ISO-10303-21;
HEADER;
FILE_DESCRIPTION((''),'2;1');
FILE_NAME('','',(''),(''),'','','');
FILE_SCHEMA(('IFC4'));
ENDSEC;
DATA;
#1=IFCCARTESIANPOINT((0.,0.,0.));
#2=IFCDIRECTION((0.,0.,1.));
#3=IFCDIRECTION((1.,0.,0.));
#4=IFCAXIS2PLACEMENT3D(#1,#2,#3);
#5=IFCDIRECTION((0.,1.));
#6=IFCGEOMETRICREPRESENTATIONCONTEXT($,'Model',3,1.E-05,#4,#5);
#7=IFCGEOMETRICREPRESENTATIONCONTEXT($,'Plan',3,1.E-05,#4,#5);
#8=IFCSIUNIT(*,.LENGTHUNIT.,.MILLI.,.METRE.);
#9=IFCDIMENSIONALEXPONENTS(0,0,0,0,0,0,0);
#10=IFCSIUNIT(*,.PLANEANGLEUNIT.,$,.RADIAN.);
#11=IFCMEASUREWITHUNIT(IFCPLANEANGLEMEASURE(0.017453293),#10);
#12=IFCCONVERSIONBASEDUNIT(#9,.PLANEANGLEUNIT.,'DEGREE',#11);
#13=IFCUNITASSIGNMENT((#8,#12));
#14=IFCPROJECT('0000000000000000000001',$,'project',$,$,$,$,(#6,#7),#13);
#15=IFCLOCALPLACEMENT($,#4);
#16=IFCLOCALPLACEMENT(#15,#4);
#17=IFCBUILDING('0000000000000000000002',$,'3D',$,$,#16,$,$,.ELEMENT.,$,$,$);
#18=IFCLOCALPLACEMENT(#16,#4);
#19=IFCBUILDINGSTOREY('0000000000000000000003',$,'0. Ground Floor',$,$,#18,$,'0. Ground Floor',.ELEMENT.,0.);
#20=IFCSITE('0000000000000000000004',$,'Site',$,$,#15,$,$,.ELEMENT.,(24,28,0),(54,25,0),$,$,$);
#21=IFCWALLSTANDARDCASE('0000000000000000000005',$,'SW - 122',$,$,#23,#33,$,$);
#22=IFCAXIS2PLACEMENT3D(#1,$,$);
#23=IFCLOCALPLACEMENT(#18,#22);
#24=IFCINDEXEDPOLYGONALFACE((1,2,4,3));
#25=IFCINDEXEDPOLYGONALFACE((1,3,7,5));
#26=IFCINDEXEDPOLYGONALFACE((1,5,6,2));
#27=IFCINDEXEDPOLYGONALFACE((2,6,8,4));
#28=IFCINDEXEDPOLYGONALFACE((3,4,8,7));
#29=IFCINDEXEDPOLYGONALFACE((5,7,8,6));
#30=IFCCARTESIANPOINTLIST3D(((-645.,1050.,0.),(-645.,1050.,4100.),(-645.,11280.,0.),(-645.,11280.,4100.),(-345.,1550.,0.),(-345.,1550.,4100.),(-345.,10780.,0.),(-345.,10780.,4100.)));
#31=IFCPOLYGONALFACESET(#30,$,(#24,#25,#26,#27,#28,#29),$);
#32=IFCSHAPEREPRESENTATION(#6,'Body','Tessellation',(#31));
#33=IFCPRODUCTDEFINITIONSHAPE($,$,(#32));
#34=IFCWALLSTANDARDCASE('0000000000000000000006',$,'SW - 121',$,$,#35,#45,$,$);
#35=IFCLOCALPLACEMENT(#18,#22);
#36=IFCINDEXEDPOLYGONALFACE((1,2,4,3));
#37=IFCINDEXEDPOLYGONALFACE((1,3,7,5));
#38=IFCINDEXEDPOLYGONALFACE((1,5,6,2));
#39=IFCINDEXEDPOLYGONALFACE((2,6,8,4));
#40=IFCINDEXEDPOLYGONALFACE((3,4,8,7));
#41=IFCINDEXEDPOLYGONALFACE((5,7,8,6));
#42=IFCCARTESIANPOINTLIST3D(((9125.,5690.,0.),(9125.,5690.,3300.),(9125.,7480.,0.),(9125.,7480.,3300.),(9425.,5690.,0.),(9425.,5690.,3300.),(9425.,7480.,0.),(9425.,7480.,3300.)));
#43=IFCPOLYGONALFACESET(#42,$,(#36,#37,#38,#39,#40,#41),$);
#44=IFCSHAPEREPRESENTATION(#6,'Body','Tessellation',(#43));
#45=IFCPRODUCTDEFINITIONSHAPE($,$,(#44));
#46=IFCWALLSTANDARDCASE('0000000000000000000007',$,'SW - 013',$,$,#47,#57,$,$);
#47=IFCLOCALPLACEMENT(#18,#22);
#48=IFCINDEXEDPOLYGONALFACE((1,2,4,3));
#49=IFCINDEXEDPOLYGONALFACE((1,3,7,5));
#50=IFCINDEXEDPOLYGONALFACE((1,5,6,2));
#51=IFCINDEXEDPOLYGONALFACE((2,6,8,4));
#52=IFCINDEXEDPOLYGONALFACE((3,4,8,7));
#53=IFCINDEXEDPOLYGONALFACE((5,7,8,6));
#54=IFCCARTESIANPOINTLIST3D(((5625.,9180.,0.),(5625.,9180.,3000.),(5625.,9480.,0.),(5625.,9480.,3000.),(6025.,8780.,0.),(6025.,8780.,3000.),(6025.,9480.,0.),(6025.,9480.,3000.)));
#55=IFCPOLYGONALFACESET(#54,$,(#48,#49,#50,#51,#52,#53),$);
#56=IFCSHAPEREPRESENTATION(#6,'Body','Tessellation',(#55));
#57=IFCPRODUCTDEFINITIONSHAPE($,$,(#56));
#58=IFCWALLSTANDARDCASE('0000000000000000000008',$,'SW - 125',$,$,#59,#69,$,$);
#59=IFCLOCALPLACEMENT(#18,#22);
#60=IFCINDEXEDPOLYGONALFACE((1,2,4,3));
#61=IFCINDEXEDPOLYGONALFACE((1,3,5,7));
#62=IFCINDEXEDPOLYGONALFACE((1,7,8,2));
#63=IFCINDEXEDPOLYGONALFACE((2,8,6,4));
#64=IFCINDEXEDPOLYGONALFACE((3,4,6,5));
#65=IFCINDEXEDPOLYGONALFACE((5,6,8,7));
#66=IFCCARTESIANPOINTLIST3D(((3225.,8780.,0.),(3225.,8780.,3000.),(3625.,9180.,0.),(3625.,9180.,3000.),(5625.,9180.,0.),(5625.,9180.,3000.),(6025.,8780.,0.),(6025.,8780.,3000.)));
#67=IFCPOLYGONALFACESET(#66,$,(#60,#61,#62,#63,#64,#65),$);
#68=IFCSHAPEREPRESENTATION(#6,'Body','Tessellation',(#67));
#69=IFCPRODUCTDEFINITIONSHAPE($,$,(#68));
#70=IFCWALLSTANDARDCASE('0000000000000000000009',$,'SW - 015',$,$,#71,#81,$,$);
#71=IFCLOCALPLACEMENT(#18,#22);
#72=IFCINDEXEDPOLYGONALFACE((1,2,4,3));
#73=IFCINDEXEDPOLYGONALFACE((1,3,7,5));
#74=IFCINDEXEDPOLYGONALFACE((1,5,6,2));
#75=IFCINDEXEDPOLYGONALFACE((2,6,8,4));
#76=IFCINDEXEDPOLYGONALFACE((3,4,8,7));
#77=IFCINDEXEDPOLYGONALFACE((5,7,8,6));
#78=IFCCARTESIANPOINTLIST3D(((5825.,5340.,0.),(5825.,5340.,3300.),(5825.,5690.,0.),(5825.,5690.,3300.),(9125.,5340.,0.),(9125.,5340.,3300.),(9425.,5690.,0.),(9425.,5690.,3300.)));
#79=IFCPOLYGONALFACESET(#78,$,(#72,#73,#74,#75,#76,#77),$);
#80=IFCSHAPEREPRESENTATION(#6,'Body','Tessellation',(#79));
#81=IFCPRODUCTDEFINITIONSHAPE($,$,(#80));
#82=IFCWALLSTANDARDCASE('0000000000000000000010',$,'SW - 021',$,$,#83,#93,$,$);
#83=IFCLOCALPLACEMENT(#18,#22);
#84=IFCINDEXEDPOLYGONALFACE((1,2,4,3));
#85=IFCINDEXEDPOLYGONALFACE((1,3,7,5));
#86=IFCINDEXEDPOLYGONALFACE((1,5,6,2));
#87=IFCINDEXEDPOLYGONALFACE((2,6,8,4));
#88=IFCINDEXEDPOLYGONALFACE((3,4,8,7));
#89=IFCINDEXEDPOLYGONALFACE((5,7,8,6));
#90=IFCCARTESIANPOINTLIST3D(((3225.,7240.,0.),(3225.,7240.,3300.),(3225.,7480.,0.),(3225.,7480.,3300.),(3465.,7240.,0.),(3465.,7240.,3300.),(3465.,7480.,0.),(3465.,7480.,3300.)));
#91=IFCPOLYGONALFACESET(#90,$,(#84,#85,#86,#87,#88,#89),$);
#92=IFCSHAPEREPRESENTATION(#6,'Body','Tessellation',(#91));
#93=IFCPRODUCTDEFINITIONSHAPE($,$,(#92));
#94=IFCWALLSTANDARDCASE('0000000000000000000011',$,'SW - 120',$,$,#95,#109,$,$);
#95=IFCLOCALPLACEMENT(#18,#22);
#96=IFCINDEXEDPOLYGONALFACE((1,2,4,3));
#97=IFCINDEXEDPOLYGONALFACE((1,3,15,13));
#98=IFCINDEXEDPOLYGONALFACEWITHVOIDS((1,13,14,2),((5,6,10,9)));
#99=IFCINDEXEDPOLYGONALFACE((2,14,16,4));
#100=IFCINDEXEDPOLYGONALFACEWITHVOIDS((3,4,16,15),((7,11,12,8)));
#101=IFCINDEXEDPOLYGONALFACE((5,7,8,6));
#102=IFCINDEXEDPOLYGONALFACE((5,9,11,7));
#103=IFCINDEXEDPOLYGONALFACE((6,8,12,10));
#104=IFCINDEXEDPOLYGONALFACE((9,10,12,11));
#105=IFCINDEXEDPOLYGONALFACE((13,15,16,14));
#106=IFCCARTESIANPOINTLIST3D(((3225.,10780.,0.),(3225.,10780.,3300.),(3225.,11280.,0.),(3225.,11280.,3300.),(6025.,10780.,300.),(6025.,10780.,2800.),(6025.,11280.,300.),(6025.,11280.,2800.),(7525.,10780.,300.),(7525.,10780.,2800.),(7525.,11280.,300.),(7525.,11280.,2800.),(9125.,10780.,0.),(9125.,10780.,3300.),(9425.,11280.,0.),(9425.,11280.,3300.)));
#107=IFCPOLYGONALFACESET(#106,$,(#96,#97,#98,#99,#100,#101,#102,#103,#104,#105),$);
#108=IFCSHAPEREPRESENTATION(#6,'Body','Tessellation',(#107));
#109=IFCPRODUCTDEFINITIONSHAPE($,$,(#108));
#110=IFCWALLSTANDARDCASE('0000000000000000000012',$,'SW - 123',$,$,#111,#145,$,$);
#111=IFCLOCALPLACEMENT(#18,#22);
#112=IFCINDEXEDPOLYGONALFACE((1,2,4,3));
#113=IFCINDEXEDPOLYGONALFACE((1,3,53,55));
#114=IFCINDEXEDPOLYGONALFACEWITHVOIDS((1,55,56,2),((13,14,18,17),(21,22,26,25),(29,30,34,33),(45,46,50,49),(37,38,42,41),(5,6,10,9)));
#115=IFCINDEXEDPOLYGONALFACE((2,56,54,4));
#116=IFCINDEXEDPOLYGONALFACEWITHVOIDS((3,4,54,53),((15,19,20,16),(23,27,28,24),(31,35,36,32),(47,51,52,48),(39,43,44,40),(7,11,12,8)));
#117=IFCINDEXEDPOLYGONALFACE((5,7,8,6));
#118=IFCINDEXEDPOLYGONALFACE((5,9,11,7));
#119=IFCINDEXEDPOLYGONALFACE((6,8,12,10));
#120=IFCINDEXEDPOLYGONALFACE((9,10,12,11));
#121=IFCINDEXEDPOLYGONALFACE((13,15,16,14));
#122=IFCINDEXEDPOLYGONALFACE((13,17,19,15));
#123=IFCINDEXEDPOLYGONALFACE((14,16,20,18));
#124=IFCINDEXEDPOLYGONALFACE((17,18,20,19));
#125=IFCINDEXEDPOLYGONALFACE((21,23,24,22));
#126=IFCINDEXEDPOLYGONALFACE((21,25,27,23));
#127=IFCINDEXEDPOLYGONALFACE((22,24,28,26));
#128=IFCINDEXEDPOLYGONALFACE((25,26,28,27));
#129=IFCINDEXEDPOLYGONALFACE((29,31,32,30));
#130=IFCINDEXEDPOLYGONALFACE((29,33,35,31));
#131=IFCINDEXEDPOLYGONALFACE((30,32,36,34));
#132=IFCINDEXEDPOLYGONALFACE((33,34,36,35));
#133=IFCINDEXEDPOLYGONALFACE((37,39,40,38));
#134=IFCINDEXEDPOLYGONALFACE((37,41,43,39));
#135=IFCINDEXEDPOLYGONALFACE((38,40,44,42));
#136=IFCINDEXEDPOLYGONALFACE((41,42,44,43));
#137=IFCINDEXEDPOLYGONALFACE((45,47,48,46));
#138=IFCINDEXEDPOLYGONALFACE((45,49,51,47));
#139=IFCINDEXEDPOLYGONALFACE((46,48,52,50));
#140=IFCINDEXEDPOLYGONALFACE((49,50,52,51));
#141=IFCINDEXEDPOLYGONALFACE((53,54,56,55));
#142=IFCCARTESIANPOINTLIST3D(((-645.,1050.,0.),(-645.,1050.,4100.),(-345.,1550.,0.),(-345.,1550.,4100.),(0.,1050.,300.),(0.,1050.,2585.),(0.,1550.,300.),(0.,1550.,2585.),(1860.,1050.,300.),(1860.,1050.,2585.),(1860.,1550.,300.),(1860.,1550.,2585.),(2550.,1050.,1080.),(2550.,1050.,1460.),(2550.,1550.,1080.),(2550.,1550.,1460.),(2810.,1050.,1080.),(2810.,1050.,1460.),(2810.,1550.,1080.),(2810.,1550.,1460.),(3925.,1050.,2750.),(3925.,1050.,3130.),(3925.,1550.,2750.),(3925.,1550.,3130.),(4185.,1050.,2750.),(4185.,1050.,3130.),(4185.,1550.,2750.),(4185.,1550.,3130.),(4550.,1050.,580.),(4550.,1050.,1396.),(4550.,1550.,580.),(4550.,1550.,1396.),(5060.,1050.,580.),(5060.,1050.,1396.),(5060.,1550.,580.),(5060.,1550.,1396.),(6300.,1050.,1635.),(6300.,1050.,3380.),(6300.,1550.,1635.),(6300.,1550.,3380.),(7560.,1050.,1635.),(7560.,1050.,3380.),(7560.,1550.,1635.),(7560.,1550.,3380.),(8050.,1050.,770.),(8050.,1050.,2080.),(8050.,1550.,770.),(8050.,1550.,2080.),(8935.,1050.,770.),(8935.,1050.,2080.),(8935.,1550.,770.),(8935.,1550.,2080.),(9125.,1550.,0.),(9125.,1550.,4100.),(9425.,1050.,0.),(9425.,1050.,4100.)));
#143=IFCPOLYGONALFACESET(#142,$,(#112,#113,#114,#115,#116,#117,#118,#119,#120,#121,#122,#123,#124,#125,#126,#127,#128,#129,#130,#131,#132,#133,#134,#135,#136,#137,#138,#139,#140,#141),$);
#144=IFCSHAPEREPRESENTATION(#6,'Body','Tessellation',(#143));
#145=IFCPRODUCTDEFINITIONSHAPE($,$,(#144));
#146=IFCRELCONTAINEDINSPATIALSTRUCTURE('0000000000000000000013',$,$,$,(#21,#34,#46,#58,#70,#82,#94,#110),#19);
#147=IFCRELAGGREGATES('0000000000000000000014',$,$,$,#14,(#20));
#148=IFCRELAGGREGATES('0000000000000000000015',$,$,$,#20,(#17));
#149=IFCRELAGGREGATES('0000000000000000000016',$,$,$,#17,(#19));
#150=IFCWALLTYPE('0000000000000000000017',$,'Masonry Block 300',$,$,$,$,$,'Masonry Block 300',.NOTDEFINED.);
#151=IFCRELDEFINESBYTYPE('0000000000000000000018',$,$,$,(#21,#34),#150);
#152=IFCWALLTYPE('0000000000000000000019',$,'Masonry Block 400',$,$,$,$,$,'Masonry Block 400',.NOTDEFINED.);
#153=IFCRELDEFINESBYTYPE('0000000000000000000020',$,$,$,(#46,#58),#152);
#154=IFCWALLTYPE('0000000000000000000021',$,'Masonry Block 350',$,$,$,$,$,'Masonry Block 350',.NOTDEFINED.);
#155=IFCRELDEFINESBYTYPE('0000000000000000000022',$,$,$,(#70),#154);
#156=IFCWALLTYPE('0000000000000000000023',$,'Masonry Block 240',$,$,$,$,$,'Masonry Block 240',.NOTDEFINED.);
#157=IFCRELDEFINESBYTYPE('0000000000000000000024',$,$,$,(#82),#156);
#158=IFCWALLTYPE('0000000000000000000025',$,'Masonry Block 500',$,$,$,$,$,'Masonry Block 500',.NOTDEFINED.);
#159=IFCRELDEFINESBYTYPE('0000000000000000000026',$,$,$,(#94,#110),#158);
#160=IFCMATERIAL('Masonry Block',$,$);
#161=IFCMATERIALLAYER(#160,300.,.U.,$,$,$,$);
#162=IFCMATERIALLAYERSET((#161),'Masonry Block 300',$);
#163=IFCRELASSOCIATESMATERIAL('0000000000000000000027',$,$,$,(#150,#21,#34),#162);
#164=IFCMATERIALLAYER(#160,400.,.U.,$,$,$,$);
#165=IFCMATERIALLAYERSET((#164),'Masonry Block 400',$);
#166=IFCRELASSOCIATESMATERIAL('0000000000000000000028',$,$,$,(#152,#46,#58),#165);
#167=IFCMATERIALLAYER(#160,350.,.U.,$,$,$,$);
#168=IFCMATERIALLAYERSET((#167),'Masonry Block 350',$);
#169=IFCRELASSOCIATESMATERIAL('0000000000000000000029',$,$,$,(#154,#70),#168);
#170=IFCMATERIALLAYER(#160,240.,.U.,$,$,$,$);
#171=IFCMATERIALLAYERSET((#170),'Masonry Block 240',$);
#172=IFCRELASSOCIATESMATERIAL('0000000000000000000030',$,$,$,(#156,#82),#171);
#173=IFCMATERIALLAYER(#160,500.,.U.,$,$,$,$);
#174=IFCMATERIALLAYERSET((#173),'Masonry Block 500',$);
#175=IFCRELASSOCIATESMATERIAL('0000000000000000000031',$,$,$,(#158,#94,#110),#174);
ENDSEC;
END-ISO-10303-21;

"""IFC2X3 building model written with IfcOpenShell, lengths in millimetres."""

from ifc_helpers import new_model, entity, si_unit, converted_unit, direction, frame, frame_2d, origin_with_axes, place, context, project, spatial, polyline, rectangle, outline, extrude, material, layer, layer_set, layer_usage, type_object, element, save


model = new_model("IFC2X3")

# Units and contexts
model_context = context("Model", 3, precision=1e-05, world=origin_with_axes(), true_north=direction((0.0, 1.0)))
plan_context = context("Plan", 3, precision=1e-05, world=origin_with_axes(), true_north=direction((0.0, 1.0)))
ifc_project = project(units=[si_unit("LENGTHUNIT", "METRE", prefix="MILLI"), converted_unit("PLANEANGLEUNIT", "DEGREE", entity("IfcPlaneAngleMeasure", 0.017453293), si_unit("PLANEANGLEUNIT", "RADIAN"), dimensions=[0, 0, 0, 0, 0, 0, 0])], contexts=[model_context, plan_context])

# Site, building, storey
site_placement = place(None, origin_with_axes())
site = spatial("IfcSite", under=ifc_project, at=site_placement, Name="Site", CompositionType="ELEMENT", RefLatitude=(24, 28, 0), RefLongitude=(54, 25, 0))
building_placement = place(site_placement, origin_with_axes())
building = spatial("IfcBuilding", under=site, at=building_placement, Name="3D", CompositionType="ELEMENT")
storey_placement = place(building_placement, origin_with_axes())
storey = spatial("IfcBuildingStorey", under=building, at=storey_placement, Name="0. Ground Floor", LongName="0. Ground Floor", CompositionType="ELEMENT", Elevation=0.0)

# Shared definitions
ifc_material_1 = material(Name="Masonry Block")
ifc_layer_1 = layer(ifc_material_1, 300.0, ventilated="UNKNOWN")
ifc_layer_set_1 = layer_set([ifc_layer_1], Name="Masonry Block 300")

# Walls
wall_type_1 = type_object("IfcWallType", Name="Masonry Block 300", ElementType="Masonry Block 300", PredefinedType="NOTDEFINED", material=ifc_layer_set_1)
ifc_layer_usage_1 = layer_usage(ifc_layer_set_1, "AXIS2", "POSITIVE", 0.0)
wall_1_placement = place(storey_placement, frame((-645.0, 11280.0, 0.0), z_axis=(0.0, 0.0, 1.0), x_axis=(0.0, -1.0, 0.0)))
element("IfcWallStandardCase", 1, at=wall_1_placement, inside=storey, type_object=wall_type_1, material=ifc_layer_usage_1, Name="SW - 122", context=model_context, shape_type="SweptSolid", body=[
    extrude(outline(polyline([(0.0, 0.0), (10230.0, 0.0), (9730.0, 300.0), (500.0, 300.0), (0.0, 0.0)])), origin_with_axes(), (0.0, 0.0, 1.0), 4100.0),
])
ifc_layer_usage_2 = layer_usage(ifc_layer_set_1, "AXIS2", "NEGATIVE", 0.0)
wall_2_placement = place(storey_placement, frame((9425.0, 7480.0, 0.0), z_axis=(0.0, 0.0, 1.0), x_axis=(0.0, -1.0, 0.0)))
element("IfcWallStandardCase", 2, at=wall_2_placement, inside=storey, type_object=wall_type_1, material=ifc_layer_usage_2, Name="SW - 121", context=model_context, shape_type="SweptSolid", body=[
    extrude(outline(polyline([(0.0, -300.0), (1790.0, -300.0), (1790.0, 0.0), (0.0, 0.0), (0.0, -300.0)])), origin_with_axes(), (0.0, 0.0, 1.0), 3300.0),
])
ifc_layer_2 = layer(ifc_material_1, 400.0, ventilated="UNKNOWN")
ifc_layer_set_2 = layer_set([ifc_layer_2], Name="Masonry Block 400")
wall_type_2 = type_object("IfcWallType", Name="Masonry Block 400", ElementType="Masonry Block 400", PredefinedType="NOTDEFINED", material=ifc_layer_set_2)
ifc_layer_usage_3 = layer_usage(ifc_layer_set_2, "AXIS2", "POSITIVE", 0.0)
wall_3_placement = place(storey_placement, frame((6025.0, 8780.0, 0.0), z_axis=(0.0, 0.0, 1.0), x_axis=(0.0, 1.0, 0.0)))
element("IfcWallStandardCase", 3, at=wall_3_placement, inside=storey, type_object=wall_type_2, material=ifc_layer_usage_3, Name="SW - 013", context=model_context, shape_type="SweptSolid", body=[
    extrude(outline(polyline([(0.0, 0.0), (700.0, 0.0), (700.0, 400.0), (400.0, 400.0), (0.0, 0.0)])), origin_with_axes(), (0.0, 0.0, 1.0), 3000.0),
])
ifc_layer_usage_4 = layer_usage(ifc_layer_set_2, "AXIS2", "POSITIVE", 0.0)
wall_4_placement = place(storey_placement, frame((3225.0, 8780.0, 0.0), z_axis=(0.0, 0.0, 1.0), x_axis=(1.0, 0.0, 0.0)))
element("IfcWallStandardCase", 4, at=wall_4_placement, inside=storey, type_object=wall_type_2, material=ifc_layer_usage_4, Name="SW - 125", context=model_context, shape_type="SweptSolid", body=[
    extrude(outline(polyline([(0.0, 0.0), (2800.0, 0.0), (2400.0, 400.0), (400.0, 400.0), (0.0, 0.0)])), origin_with_axes(), (0.0, 0.0, 1.0), 3000.0),
])
ifc_layer_3 = layer(ifc_material_1, 350.0, ventilated="UNKNOWN")
ifc_layer_set_3 = layer_set([ifc_layer_3], Name="Masonry Block 350")
ifc_layer_usage_5 = layer_usage(ifc_layer_set_3, "AXIS2", "POSITIVE", 0.0)
wall_type_3 = type_object("IfcWallType", Name="Masonry Block 350", ElementType="Masonry Block 350", PredefinedType="NOTDEFINED", material=ifc_layer_set_3)
wall_5_placement = place(storey_placement, frame((5825.0, 5340.0, 0.0), z_axis=(0.0, 0.0, 1.0), x_axis=(1.0, 0.0, 0.0)))
element("IfcWallStandardCase", 5, at=wall_5_placement, inside=storey, type_object=wall_type_3, material=ifc_layer_usage_5, Name="SW - 015", context=model_context, shape_type="SweptSolid", body=[
    extrude(outline(polyline([(0.0, 0.0), (3300.0, 0.0), (3600.0, 350.0), (0.0, 350.0), (0.0, 0.0)])), origin_with_axes(), (0.0, 0.0, 1.0), 3300.0),
])
ifc_layer_4 = layer(ifc_material_1, 240.0, ventilated="UNKNOWN")
ifc_layer_set_4 = layer_set([ifc_layer_4], Name="Masonry Block 240")
ifc_layer_usage_6 = layer_usage(ifc_layer_set_4, "AXIS2", "NEGATIVE", 0.0)
wall_type_4 = type_object("IfcWallType", Name="Masonry Block 240", ElementType="Masonry Block 240", PredefinedType="NOTDEFINED", material=ifc_layer_set_4)
wall_6_placement = place(storey_placement, frame((3225.0, 7240.0, 0.0), z_axis=(0.0, 0.0, 1.0), x_axis=(0.0, 1.0, 0.0)))
element("IfcWallStandardCase", 6, at=wall_6_placement, inside=storey, type_object=wall_type_4, material=ifc_layer_usage_6, Name="SW - 021", context=model_context, shape_type="SweptSolid", body=[
    extrude(outline(polyline([(0.0, -240.0), (240.0, -240.0), (240.0, 0.0), (0.0, 0.0), (0.0, -240.0)])), origin_with_axes(), (0.0, 0.0, 1.0), 3300.0),
])

# Wall, opening
ifc_layer_5 = layer(ifc_material_1, 500.0, ventilated="UNKNOWN")
ifc_layer_set_5 = layer_set([ifc_layer_5], Name="Masonry Block 500")
ifc_layer_usage_7 = layer_usage(ifc_layer_set_5, "AXIS2", "NEGATIVE", 0.0)
wall_type_5 = type_object("IfcWallType", Name="Masonry Block 500", ElementType="Masonry Block 500", PredefinedType="NOTDEFINED", material=ifc_layer_set_5)
wall_7_placement = place(storey_placement, frame((3225.0, 11280.0, 0.0), z_axis=(0.0, 0.0, 1.0), x_axis=(1.0, 0.0, 0.0)))
wall_7 = element("IfcWallStandardCase", 7, at=wall_7_placement, inside=storey, type_object=wall_type_5, material=ifc_layer_usage_7, Name="SW - 120", context=model_context, shape_type="SweptSolid", body=[
    extrude(outline(polyline([(0.0, -500.0), (5900.0, -500.0), (6200.0, 0.0), (0.0, 0.0), (0.0, -500.0)])), origin_with_axes(), (0.0, 0.0, 1.0), 3300.0),
])
opening_1_placement = place(wall_7_placement, frame((3550.0, -500.0, 300.0), z_axis=(0.0, 0.0, 1.0), x_axis=(1.0, 0.0, 0.0)))
element("IfcOpeningElement", 8, at=opening_1_placement, cuts=wall_7, ObjectType="Opening", context=model_context, shape_type="SweptSolid", body=[
    extrude(rectangle(XDim=1500.0, YDim=2500.0, at=frame_2d((0.0, 1250.0), x_axis=(1.0, 0.0))), frame((0.0, 0.0, 0.0), z_axis=(0.0, 1.0, 0.0), x_axis=(-1.0, 0.0, 0.0)), (0.0, 0.0, 1.0), 500.0),
])

# Wall, openings
ifc_layer_usage_8 = layer_usage(ifc_layer_set_5, "AXIS2", "POSITIVE", 0.0)
wall_8_placement = place(storey_placement, frame((-645.0, 1050.0, 0.0), z_axis=(0.0, 0.0, 1.0), x_axis=(1.0, 0.0, 0.0)))
wall_8 = element("IfcWallStandardCase", 9, at=wall_8_placement, inside=storey, type_object=wall_type_5, material=ifc_layer_usage_8, Name="SW - 123", context=model_context, shape_type="SweptSolid", body=[
    extrude(outline(polyline([(0.0, 0.0), (10070.0, 0.0), (9770.0, 500.0), (300.0, 500.0), (0.0, 0.0)])), origin_with_axes(), (0.0, 0.0, 1.0), 4100.0),
])
opening_2_placement = place(wall_8_placement, frame((7575.0, 0.0, 1635.0), z_axis=(0.0, 0.0, 1.0), x_axis=(1.0, 0.0, 0.0)))
element("IfcOpeningElement", 10, at=opening_2_placement, cuts=wall_8, ObjectType="Opening", context=model_context, shape_type="SweptSolid", body=[
    extrude(rectangle(XDim=1260.0, YDim=1745.0, at=frame_2d((0.0, 872.5), x_axis=(1.0, 0.0))), frame((0.0, 0.0, 0.0), z_axis=(0.0, 1.0, 0.0), x_axis=(-1.0, 0.0, 0.0)), (0.0, 0.0, 1.0), 500.0),
])
opening_3_placement = place(wall_8_placement, frame((1575.0, 0.0, 300.0), z_axis=(0.0, 0.0, 1.0), x_axis=(1.0, 0.0, 0.0)))
element("IfcOpeningElement", 11, at=opening_3_placement, cuts=wall_8, ObjectType="Opening", context=model_context, shape_type="SweptSolid", body=[
    extrude(rectangle(XDim=1860.0, YDim=2285.0, at=frame_2d((0.0, 1142.5), x_axis=(1.0, 0.0))), frame((0.0, 0.0, 0.0), z_axis=(0.0, 1.0, 0.0), x_axis=(-1.0, 0.0, 0.0)), (0.0, 0.0, 1.0), 500.0),
])
opening_4_placement = place(wall_8_placement, frame((3325.0, 0.0, 1080.0), z_axis=(0.0, 0.0, 1.0), x_axis=(1.0, 0.0, 0.0)))
element("IfcOpeningElement", 12, at=opening_4_placement, cuts=wall_8, ObjectType="Opening", context=model_context, shape_type="SweptSolid", body=[
    extrude(rectangle(XDim=260.0, YDim=380.0, at=frame_2d((0.0, 190.0), x_axis=(-1.0, 0.0))), frame((0.0, 0.0, 0.0), z_axis=(0.0, 1.0, 0.0), x_axis=(-1.0, 0.0, 0.0)), (0.0, 0.0, 1.0), 500.0),
])
opening_5_placement = place(wall_8_placement, frame((9137.5, 0.0, 770.0), z_axis=(0.0, 0.0, 1.0), x_axis=(1.0, 0.0, 0.0)))
element("IfcOpeningElement", 13, at=opening_5_placement, cuts=wall_8, ObjectType="Opening", context=model_context, shape_type="SweptSolid", body=[
    extrude(rectangle(XDim=885.0, YDim=1310.0, at=frame_2d((0.0, 655.0), x_axis=(-1.0, 0.0))), frame((0.0, 0.0, 0.0), z_axis=(0.0, 1.0, 0.0), x_axis=(-1.0, 0.0, 0.0)), (0.0, 0.0, 1.0), 500.0),
])
opening_6_placement = place(wall_8_placement, frame((4700.0, 0.0, 2750.0), z_axis=(0.0, 0.0, 1.0), x_axis=(1.0, 0.0, 0.0)))
element("IfcOpeningElement", 14, at=opening_6_placement, cuts=wall_8, ObjectType="Opening", context=model_context, shape_type="SweptSolid", body=[
    extrude(rectangle(XDim=260.0, YDim=380.0, at=frame_2d((0.0, 190.0), x_axis=(1.0, 0.0))), frame((0.0, 0.0, 0.0), z_axis=(0.0, 1.0, 0.0), x_axis=(-1.0, 0.0, 0.0)), (0.0, 0.0, 1.0), 500.0),
])
opening_7_placement = place(wall_8_placement, frame((5450.0, 0.0, 580.0), z_axis=(0.0, 0.0, 1.0), x_axis=(1.0, 0.0, 0.0)))
element("IfcOpeningElement", 15, at=opening_7_placement, cuts=wall_8, ObjectType="Opening", context=model_context, shape_type="SweptSolid", body=[
    extrude(rectangle(XDim=510.0, YDim=816.0, at=frame_2d((0.0, 408.0), x_axis=(-1.0, 0.0))), frame((0.0, 0.0, 0.0), z_axis=(0.0, 1.0, 0.0), x_axis=(-1.0, 0.0, 0.0)), (0.0, 0.0, 1.0), 500.0),
])

save(model, "model.ifc")
